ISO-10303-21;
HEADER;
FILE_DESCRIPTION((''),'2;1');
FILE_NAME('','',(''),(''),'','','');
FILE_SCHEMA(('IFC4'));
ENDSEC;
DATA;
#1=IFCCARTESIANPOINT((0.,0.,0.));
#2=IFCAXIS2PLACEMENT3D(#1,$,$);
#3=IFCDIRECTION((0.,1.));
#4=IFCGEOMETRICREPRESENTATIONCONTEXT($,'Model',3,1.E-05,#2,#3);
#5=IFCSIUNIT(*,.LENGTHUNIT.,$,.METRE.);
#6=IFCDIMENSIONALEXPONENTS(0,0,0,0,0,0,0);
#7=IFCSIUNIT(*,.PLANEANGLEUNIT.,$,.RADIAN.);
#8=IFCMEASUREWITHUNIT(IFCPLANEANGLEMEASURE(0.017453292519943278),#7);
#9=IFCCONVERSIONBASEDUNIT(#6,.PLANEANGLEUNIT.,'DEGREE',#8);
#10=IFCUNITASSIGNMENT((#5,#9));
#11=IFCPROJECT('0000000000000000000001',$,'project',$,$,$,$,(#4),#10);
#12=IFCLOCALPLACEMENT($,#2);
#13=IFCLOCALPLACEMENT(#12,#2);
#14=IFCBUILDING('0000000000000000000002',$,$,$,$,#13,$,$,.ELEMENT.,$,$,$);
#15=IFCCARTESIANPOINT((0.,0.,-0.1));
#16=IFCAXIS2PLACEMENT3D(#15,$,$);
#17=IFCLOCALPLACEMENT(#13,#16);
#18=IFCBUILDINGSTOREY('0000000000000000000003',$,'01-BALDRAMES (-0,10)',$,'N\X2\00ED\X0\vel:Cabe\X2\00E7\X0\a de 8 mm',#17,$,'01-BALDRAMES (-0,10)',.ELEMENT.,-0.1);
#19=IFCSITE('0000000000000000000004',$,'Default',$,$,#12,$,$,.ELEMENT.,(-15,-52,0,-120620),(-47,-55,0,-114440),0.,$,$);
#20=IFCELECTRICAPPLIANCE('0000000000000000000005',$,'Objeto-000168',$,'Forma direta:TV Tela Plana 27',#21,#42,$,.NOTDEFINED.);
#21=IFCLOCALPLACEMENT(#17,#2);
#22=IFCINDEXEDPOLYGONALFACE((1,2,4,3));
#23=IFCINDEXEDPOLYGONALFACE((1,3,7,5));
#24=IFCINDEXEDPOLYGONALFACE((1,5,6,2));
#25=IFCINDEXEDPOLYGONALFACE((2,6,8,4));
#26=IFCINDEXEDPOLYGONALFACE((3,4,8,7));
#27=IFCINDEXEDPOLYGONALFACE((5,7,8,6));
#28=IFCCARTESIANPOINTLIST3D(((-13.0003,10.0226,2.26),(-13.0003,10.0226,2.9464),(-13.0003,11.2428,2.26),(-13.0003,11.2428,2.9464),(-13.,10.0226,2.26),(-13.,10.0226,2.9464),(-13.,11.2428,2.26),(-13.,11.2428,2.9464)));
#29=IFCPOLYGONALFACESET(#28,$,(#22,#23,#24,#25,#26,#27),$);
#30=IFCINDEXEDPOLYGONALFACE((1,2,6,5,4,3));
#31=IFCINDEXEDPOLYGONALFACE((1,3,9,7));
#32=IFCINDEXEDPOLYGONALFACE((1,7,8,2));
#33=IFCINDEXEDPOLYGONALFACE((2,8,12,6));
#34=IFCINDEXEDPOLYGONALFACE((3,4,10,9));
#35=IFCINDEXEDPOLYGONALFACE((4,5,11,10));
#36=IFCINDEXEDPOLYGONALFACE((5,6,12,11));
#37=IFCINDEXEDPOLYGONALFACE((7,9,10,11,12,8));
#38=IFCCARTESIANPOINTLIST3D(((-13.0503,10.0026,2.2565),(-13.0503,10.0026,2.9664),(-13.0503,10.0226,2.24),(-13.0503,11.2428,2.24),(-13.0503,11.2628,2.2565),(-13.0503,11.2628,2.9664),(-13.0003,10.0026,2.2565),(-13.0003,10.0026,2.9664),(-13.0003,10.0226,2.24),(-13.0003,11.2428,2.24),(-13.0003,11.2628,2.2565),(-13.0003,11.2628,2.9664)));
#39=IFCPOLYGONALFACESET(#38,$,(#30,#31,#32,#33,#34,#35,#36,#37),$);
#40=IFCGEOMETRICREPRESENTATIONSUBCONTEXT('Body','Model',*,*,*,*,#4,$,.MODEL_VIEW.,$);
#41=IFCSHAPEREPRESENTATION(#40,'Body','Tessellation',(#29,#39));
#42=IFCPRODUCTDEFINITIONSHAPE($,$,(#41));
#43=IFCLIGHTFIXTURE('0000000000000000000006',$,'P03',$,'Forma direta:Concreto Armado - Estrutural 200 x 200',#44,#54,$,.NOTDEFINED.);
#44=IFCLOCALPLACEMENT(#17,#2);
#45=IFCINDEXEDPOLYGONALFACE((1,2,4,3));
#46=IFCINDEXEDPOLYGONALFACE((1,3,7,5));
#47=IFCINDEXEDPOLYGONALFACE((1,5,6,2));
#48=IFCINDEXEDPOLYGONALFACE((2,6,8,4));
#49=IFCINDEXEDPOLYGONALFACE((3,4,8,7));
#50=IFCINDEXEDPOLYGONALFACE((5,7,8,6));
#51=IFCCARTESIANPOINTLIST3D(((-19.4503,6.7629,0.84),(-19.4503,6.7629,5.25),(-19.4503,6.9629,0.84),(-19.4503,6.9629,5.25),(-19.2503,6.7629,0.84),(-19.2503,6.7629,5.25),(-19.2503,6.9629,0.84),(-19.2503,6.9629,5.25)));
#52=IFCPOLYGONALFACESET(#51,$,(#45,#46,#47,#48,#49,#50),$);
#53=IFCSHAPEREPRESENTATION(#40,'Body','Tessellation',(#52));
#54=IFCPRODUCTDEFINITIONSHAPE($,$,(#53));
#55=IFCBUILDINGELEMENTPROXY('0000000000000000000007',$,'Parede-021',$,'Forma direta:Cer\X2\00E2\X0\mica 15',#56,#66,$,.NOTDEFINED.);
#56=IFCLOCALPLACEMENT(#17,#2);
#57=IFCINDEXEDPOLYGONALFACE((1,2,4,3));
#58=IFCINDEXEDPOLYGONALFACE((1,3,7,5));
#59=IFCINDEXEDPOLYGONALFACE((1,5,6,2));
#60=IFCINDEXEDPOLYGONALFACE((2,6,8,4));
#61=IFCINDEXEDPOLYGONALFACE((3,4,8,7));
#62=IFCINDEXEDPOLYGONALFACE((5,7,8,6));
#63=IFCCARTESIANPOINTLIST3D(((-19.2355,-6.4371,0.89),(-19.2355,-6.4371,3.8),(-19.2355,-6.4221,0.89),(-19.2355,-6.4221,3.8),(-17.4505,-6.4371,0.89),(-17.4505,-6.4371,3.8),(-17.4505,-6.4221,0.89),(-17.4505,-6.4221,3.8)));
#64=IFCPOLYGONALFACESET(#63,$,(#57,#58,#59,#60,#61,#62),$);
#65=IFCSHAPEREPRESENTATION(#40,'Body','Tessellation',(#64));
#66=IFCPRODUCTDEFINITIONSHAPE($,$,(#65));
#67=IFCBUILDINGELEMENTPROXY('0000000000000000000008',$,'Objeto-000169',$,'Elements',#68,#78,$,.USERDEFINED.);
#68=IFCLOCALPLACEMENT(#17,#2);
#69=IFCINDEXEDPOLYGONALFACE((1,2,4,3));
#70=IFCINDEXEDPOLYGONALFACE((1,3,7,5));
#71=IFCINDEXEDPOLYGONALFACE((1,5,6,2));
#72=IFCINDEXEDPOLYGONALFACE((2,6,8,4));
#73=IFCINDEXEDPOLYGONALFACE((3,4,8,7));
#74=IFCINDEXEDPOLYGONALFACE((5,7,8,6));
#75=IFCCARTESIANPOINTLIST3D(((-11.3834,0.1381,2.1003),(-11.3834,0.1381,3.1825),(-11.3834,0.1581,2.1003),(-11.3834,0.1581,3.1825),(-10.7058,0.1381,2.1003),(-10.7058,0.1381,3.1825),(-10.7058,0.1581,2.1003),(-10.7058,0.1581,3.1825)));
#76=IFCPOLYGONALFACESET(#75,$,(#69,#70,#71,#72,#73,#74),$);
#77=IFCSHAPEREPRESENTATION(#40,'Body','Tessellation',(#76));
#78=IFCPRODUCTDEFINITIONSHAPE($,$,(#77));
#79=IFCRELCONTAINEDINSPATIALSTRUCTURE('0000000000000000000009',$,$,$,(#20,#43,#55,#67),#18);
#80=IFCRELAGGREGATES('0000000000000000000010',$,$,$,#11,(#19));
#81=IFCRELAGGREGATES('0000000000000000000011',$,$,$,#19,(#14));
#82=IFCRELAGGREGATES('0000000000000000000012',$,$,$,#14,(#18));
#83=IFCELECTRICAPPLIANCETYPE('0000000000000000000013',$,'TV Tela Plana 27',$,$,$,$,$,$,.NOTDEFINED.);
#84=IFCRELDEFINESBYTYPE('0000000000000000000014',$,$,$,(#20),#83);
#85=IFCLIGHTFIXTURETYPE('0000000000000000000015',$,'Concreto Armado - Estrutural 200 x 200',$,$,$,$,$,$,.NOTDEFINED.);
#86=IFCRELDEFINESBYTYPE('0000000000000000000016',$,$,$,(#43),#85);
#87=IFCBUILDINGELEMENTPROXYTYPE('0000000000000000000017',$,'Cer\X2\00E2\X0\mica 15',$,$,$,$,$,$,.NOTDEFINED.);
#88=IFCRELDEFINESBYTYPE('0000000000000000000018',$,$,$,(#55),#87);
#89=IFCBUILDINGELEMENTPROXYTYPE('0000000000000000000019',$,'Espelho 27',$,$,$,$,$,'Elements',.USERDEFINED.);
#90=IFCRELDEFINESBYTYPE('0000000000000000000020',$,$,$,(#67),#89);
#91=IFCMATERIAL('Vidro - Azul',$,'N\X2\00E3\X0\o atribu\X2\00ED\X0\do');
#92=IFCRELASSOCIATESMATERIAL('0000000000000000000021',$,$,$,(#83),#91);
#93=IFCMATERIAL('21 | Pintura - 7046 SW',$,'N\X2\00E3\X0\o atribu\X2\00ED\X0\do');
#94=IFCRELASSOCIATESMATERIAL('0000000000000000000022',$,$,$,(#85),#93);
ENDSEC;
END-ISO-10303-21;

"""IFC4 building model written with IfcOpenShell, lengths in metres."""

from ifc_helpers import new_model, entity, si_unit, converted_unit, direction, frame, origin, place, context, subcontext, project, spatial, indexed_curve, outline, extrude, material, type_object, element, save


model = new_model("IFC4")

# Units and contexts
model_context = context("Model", 3, precision=1e-05, world=origin(), true_north=direction((0.0, 1.0)))
body_context = subcontext(model_context, "Body", "Model", "MODEL_VIEW")
ifc_project = project(units=[si_unit("LENGTHUNIT", "METRE"), converted_unit("PLANEANGLEUNIT", "DEGREE", entity("IfcPlaneAngleMeasure", 0.017453292519943278), si_unit("PLANEANGLEUNIT", "RADIAN"), dimensions=[0, 0, 0, 0, 0, 0, 0])], contexts=[model_context])

# Site, building, storey
site_placement = place(None, origin())
site = spatial("IfcSite", under=ifc_project, at=site_placement, Name="Default", CompositionType="ELEMENT", RefLatitude=(-15, -52, 0, -120620), RefLongitude=(-47, -55, 0, -114440), RefElevation=0.0)
building_placement = place(site_placement, origin())
building = spatial("IfcBuilding", under=site, at=building_placement, CompositionType="ELEMENT")
storey_placement = place(building_placement, frame((0.0, 0.0, -0.1)))
storey = spatial("IfcBuildingStorey", under=building, at=storey_placement, Name="01-BALDRAMES (-0,10)", ObjectType="Nível:Cabeça de 8 mm", LongName="01-BALDRAMES (-0,10)", CompositionType="ELEMENT", Elevation=-0.1)

# Shared definitions
ifc_material_1 = material(Name="21 | Pintura - 7046 SW", Category="Não atribuído")

# Electric appliance
ifc_material_2 = material(Name="Vidro - Azul", Category="Não atribuído")
electric_appliance_type = type_object("IfcElectricApplianceType", Name="TV Tela Plana 27", PredefinedType="NOTDEFINED", material=ifc_material_2)
electric_appliance_placement = place(storey_placement, origin())
element("IfcElectricAppliance", 1, at=electric_appliance_placement, inside=storey, type_object=electric_appliance_type, Name="Objeto-000168", ObjectType="Forma direta:TV Tela Plana 27", PredefinedType="NOTDEFINED", context=body_context, shape_type="SweptSolid", body=[
    extrude(outline(indexed_curve([(-0.6101, -0.0002), (0.6101, -0.0002), (0.6101, 0.0001), (-0.6101, 0.0001), (-0.6101, -0.0002)], self_intersect=False)), frame((-13.0002, 10.6327, 2.26), z_axis=(0.0, 0.0, 1.0), x_axis=(0.000013, 1.0, 0.0)), (0.0, 0.0, 1.0), 0.6864),
    extrude(outline(indexed_curve([(-0.6101, -0.2476), (0.6101, -0.2476), (0.6301, -0.2311), (0.6301, 0.4787), (-0.6301, 0.4787), (-0.6301, -0.2311), (-0.6101, -0.2476)], self_intersect=False)), frame((-13.0503, 10.6327, 2.4876), z_axis=(1.0, -0.000013, 0.0), x_axis=(0.000013, 1.0, 0.0)), (0.0, 0.0, 1.0), 0.05),
])

# Light fixture
light_fixture_type_1 = type_object("IfcLightFixtureType", Name="Concreto Armado - Estrutural 200 x 200", PredefinedType="NOTDEFINED", material=ifc_material_1)
light_fixture_1_placement = place(storey_placement, origin())
element("IfcLightFixture", 2, at=light_fixture_1_placement, inside=storey, type_object=light_fixture_type_1, Name="P03", ObjectType="Forma direta:Concreto Armado - Estrutural 200 x 200", PredefinedType="NOTDEFINED", context=body_context, shape_type="SweptSolid", body=[
    extrude(outline(indexed_curve([(-0.1, -0.1), (0.1, -0.1), (0.1, 0.1), (-0.1, 0.1), (-0.1, -0.1)], self_intersect=False)), frame((-19.3503, 6.8629, 0.84), z_axis=(0.0, 0.0, 1.0), x_axis=(-0.000013, -1.0, 0.0)), (0.0, 0.0, 1.0), 4.41),
])

# Building element proxies
building_element_proxy_type_1 = type_object("IfcBuildingElementProxyType", Name="Cerâmica 15", PredefinedType="NOTDEFINED")
proxy_1_placement = place(storey_placement, origin())
element("IfcBuildingElementProxy", 3, at=proxy_1_placement, inside=storey, type_object=building_element_proxy_type_1, Name="Parede-021", ObjectType="Forma direta:Cerâmica 15", PredefinedType="NOTDEFINED", context=body_context, shape_type="SweptSolid", body=[
    extrude(outline(indexed_curve([(-0.0075, -0.8925), (0.0075, -0.8925), (0.0075, 0.8925), (-0.0075, 0.8925), (-0.0075, -0.8925)], self_intersect=False)), frame((-18.343, -6.4296, 0.89), z_axis=(0.0, 0.0, 1.0), x_axis=(0.000013, 1.0, 0.0)), (0.0, 0.0, 1.0), 2.91),
])
building_element_proxy_type_2 = type_object("IfcBuildingElementProxyType", Name="Espelho 27", ElementType="Elements", PredefinedType="USERDEFINED")
proxy_2_placement = place(storey_placement, origin())
element("IfcBuildingElementProxy", 4, at=proxy_2_placement, inside=storey, type_object=building_element_proxy_type_2, Name="Objeto-000169", ObjectType="Elements", PredefinedType="USERDEFINED", context=body_context, shape_type="SweptSolid", body=[
    extrude(outline(indexed_curve([(-0.01, -0.3388), (0.01, -0.3388), (0.01, 0.3388), (-0.01, 0.3388), (-0.01, -0.3388)], self_intersect=False)), frame((-11.0446, 0.1481, 2.1003), z_axis=(0.0, 0.0, 1.0), x_axis=(0.000009, 1.0, 0.0)), (0.0, 0.0, 1.0), 1.0822),
])

save(model, "model.ifc")
